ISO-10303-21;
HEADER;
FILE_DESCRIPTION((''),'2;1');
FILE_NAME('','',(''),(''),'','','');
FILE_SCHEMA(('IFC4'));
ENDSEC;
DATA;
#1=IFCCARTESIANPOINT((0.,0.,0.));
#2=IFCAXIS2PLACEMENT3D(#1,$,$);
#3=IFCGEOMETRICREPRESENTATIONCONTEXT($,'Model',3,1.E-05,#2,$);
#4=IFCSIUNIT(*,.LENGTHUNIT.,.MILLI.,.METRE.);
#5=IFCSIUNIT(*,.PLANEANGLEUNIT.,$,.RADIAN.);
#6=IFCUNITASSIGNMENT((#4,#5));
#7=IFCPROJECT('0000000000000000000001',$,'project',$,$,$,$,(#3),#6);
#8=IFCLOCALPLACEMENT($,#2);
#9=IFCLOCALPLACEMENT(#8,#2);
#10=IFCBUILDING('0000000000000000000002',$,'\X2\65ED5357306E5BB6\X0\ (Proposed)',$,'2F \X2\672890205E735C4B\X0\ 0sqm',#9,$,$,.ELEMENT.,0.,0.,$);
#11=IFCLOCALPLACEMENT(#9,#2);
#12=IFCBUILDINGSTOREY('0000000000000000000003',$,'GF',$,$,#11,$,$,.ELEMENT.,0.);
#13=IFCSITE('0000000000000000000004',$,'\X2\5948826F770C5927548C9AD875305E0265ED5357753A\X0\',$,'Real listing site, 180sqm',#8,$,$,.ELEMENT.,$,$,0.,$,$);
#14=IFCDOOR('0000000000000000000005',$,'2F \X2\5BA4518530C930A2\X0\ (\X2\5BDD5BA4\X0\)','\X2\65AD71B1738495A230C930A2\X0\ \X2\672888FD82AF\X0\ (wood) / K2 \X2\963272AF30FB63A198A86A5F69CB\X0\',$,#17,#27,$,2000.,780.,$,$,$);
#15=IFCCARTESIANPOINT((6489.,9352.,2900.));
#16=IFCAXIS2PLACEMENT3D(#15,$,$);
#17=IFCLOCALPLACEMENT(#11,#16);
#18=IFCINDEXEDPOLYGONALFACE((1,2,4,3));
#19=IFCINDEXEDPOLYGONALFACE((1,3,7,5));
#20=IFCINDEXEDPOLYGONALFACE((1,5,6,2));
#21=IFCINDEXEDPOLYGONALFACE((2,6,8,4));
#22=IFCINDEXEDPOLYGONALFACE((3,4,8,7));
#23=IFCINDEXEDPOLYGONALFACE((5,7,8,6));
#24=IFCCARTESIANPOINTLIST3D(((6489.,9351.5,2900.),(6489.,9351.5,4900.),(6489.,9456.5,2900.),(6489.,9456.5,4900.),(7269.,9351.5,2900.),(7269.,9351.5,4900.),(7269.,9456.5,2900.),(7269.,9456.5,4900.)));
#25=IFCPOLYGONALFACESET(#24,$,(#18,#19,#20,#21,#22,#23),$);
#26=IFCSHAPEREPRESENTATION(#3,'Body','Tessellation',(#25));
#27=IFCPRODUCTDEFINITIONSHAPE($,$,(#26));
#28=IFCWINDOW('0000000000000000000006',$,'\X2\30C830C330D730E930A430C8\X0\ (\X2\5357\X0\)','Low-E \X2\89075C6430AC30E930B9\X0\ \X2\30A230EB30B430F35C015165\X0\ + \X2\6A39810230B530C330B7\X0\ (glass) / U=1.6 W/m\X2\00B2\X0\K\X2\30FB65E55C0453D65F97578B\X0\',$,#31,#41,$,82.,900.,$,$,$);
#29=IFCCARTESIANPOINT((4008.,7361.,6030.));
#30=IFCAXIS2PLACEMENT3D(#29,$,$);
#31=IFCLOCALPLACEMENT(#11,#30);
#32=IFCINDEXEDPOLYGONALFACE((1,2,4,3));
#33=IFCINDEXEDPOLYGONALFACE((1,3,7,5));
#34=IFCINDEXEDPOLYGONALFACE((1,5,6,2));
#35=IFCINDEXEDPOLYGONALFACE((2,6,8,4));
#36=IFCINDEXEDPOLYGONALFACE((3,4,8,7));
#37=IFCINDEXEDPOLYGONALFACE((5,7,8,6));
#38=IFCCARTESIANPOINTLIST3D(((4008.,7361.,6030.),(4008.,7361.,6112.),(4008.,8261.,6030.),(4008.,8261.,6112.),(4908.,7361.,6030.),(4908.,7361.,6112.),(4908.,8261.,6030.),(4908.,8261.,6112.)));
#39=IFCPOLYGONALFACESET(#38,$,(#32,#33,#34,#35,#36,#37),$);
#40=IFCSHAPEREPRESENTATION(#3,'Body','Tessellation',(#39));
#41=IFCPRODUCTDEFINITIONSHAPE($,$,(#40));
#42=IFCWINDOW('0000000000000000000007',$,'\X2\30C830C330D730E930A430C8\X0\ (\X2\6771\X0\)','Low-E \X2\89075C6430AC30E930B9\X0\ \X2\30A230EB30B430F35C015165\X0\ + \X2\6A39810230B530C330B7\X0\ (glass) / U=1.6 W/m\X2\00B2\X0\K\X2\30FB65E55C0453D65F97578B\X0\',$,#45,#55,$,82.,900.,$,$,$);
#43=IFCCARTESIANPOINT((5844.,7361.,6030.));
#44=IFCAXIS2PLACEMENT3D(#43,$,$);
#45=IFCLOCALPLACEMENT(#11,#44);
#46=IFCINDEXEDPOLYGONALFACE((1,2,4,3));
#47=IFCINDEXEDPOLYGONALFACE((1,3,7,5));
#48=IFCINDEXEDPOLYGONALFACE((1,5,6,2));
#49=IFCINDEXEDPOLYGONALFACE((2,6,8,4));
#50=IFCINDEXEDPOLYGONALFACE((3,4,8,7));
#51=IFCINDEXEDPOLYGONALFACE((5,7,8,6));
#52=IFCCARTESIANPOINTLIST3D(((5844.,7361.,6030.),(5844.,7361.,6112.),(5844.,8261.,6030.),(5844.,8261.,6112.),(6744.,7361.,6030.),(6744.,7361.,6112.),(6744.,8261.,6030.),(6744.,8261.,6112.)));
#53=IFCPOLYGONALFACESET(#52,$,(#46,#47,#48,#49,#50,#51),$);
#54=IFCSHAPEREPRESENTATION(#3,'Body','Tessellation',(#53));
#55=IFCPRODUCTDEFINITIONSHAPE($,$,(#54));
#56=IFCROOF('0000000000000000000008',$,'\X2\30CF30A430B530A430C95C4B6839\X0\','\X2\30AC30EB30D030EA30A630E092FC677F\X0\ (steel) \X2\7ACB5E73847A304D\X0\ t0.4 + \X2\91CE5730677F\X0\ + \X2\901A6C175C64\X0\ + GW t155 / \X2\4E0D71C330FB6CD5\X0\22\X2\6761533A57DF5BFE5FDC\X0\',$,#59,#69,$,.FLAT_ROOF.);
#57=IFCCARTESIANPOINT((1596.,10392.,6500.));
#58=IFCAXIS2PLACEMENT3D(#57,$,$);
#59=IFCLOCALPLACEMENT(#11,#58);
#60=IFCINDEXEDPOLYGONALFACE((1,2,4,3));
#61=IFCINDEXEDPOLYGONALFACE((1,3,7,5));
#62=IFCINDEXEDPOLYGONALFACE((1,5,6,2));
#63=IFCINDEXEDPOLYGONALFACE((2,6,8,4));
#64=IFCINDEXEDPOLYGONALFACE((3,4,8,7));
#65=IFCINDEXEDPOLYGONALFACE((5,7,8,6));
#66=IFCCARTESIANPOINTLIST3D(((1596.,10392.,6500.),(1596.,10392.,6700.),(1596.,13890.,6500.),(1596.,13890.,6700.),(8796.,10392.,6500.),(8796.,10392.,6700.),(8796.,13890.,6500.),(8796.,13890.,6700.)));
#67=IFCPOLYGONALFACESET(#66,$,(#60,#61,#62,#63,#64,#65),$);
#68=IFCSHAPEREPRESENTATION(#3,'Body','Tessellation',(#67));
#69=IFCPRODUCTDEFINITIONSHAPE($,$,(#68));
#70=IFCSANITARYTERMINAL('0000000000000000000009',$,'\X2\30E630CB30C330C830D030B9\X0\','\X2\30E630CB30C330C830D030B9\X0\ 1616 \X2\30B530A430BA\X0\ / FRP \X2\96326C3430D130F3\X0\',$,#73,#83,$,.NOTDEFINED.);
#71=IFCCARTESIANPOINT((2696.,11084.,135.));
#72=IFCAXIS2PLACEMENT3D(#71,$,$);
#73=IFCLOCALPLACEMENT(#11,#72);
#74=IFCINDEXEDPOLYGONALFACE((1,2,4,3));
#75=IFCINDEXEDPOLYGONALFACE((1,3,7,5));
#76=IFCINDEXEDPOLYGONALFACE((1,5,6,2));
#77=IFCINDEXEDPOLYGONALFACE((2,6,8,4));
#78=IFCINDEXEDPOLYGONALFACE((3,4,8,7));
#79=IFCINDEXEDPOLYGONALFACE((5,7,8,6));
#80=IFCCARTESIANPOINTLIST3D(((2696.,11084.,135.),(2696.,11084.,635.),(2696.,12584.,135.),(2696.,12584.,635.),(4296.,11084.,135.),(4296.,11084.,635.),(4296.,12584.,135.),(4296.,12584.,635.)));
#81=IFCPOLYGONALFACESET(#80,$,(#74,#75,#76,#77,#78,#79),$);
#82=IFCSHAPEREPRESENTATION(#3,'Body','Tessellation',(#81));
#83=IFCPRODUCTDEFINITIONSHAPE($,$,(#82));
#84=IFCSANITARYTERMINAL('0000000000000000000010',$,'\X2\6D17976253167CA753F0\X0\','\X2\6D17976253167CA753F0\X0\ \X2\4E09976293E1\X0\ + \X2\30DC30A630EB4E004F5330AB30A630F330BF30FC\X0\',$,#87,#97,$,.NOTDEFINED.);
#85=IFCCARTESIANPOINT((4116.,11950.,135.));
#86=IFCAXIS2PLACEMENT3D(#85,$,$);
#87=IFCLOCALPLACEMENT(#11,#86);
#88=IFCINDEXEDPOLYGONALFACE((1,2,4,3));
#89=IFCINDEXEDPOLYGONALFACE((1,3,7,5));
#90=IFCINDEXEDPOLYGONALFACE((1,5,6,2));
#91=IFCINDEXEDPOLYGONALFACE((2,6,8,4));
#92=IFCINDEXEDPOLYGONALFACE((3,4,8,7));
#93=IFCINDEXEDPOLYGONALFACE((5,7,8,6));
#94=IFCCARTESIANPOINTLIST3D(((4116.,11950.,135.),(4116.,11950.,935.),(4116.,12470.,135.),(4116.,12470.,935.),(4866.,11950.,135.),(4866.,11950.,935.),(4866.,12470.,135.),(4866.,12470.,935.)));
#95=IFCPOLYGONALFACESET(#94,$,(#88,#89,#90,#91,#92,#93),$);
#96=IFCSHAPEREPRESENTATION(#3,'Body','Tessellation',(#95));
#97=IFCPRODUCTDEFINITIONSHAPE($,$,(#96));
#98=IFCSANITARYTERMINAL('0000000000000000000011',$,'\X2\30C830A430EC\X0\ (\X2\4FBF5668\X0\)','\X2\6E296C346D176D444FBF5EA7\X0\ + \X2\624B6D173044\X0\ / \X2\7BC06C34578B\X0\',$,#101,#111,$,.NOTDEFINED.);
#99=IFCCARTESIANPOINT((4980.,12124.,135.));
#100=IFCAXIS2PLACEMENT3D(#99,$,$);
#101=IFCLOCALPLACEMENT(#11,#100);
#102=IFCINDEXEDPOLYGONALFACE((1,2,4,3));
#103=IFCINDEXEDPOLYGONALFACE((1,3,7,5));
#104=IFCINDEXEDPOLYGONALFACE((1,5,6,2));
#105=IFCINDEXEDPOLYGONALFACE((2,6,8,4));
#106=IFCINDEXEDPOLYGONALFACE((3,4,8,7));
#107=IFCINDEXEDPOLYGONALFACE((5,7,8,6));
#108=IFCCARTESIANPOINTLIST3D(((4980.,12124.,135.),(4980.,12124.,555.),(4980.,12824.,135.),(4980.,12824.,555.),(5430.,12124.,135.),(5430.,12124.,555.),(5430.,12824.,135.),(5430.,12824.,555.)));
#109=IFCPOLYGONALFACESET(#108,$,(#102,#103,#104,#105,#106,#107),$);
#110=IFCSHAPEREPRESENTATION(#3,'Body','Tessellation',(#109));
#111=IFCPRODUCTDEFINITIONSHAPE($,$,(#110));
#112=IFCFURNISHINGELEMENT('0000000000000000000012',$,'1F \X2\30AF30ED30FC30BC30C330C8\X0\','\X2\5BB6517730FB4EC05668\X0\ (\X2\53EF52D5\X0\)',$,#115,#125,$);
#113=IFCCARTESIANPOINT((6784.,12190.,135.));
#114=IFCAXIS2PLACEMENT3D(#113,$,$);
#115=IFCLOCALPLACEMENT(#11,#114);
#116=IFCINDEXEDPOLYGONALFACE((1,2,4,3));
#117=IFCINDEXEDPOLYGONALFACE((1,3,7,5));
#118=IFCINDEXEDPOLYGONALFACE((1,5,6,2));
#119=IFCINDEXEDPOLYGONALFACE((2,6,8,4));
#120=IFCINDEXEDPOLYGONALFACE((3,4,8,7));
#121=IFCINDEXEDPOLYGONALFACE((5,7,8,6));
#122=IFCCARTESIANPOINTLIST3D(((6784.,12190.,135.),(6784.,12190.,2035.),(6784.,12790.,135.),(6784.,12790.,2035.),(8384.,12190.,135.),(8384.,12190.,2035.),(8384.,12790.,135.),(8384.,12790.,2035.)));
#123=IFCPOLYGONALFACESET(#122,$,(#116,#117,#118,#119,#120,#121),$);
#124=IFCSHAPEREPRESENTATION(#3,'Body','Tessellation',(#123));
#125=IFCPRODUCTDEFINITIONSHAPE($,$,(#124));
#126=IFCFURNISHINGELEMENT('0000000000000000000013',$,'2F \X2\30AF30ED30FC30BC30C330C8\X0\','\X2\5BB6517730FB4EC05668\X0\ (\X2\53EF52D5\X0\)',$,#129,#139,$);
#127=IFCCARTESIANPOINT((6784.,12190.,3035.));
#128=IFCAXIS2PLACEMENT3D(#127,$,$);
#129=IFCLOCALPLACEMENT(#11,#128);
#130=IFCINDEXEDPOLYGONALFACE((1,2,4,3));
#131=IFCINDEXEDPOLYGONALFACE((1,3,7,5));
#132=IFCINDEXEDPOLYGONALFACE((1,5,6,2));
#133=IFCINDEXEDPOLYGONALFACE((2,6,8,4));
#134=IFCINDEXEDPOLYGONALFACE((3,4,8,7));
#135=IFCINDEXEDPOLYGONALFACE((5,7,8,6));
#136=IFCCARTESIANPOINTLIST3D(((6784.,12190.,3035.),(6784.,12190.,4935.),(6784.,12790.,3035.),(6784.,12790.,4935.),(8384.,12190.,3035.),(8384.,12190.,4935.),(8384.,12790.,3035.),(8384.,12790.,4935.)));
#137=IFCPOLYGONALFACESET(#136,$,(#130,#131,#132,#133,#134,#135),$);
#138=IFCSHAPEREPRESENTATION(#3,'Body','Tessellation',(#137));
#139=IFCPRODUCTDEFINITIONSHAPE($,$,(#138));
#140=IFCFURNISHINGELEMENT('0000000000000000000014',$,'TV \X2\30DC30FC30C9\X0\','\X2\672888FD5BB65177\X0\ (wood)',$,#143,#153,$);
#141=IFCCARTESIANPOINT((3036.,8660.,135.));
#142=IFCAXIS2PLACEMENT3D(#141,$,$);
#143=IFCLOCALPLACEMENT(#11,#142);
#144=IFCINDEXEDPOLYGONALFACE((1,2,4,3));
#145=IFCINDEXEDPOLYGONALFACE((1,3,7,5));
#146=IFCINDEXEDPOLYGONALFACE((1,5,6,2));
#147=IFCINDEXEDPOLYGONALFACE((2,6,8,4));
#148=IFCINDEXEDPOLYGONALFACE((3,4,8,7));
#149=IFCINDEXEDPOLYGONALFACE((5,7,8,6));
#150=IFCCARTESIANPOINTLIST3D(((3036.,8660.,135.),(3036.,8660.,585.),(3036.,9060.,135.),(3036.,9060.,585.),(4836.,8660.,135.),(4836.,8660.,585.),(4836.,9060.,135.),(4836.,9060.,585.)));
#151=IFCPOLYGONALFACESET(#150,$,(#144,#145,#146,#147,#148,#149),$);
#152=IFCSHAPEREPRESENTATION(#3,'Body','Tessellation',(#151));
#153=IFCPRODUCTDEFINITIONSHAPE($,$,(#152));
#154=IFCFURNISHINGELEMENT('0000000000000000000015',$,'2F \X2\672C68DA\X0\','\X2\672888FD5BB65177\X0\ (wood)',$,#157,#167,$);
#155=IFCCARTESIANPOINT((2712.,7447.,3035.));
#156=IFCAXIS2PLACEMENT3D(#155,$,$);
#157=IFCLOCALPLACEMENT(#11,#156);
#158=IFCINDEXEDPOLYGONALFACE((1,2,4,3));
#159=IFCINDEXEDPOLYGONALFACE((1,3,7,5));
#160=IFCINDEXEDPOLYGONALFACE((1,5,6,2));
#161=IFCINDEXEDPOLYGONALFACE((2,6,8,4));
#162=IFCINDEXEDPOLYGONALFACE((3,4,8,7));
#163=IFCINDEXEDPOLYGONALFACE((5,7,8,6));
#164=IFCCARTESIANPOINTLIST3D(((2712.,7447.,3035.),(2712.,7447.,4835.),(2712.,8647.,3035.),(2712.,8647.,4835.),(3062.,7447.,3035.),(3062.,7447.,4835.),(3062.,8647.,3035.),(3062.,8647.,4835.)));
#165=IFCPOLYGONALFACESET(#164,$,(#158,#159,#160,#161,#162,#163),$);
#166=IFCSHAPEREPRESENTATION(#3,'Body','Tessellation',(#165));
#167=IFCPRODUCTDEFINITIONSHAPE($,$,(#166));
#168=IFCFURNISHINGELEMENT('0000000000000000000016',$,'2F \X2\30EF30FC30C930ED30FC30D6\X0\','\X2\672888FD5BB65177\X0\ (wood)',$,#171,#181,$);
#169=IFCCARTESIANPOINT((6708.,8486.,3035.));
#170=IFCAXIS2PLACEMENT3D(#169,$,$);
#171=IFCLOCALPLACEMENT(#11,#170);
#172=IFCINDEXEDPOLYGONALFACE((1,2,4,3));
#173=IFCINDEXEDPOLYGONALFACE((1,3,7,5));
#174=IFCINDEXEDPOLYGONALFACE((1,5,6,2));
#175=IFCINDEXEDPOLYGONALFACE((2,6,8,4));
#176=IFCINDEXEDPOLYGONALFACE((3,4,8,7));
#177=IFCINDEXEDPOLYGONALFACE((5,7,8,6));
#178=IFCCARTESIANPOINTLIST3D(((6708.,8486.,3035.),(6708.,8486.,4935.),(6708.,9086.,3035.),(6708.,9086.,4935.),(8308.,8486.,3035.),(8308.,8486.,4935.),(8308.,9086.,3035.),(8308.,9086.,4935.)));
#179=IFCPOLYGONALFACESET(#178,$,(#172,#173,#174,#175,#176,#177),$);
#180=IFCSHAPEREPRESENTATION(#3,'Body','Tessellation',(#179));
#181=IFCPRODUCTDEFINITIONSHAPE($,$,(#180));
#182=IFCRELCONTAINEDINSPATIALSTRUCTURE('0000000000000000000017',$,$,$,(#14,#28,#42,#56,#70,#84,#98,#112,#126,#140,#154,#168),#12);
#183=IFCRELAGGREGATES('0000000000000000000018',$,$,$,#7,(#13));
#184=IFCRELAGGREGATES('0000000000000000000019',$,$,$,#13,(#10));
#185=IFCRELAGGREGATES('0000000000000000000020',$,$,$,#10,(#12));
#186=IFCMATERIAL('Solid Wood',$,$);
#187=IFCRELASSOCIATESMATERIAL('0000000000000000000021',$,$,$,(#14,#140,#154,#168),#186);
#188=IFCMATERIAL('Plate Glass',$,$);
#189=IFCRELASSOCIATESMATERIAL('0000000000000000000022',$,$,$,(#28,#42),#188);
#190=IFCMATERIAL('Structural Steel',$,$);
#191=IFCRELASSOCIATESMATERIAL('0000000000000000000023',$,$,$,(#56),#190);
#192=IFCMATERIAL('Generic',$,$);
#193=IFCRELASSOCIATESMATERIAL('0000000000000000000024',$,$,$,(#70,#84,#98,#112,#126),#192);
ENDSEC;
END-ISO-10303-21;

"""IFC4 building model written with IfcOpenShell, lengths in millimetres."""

from ifc_helpers import new_model, si_unit, frame, frame_2d, origin, place, context, project, spatial, rectangle, extrude, material, element, save


model = new_model("IFC4")

# Units and contexts
model_context = context("Model", 3, precision=1e-05, world=origin())
ifc_project = project(units=[si_unit("LENGTHUNIT", "METRE", prefix="MILLI"), si_unit("PLANEANGLEUNIT", "RADIAN")], contexts=[model_context])

# Site, building, storey
site_placement = place(None, origin())
site = spatial("IfcSite", under=ifc_project, at=site_placement, Name="奈良県大和高田市旭南町", ObjectType="Real listing site, 180sqm", CompositionType="ELEMENT", RefElevation=0.0)
building_placement = place(site_placement, origin())
building = spatial("IfcBuilding", under=site, at=building_placement, Name="旭南の家 (Proposed)", ObjectType="2F 木造平屋 0sqm", CompositionType="ELEMENT", ElevationOfRefHeight=0.0, ElevationOfTerrain=0.0)
storey_placement = place(building_placement, origin())
storey = spatial("IfcBuildingStorey", under=building, at=storey_placement, Name="GF", CompositionType="ELEMENT", Elevation=0.0)

# Shared definitions
ifc_material_1 = material(Name="Solid Wood")
ifc_material_2 = material(Name="Plate Glass")

# Door
door_1_placement = place(storey_placement, frame((6489.0, 9352.0, 2900.0)))
element("IfcDoor", 1, at=door_1_placement, inside=storey, material=ifc_material_1, Name="2F 室内ドア (寝室)", Description="断熱玄関ドア 木製芯 (wood) / K2 防犯・採風機構", OverallHeight=2000.0, OverallWidth=780.0, context=model_context, shape_type="SweptSolid", body=[
    extrude(rectangle(XDim=780.0, YDim=105.0, at=frame_2d((390.0, 52.0))), frame((6489.0, 9352.0, 2900.0)), (0.0, 0.0, 1.0), 2000.0),
])

# Windows
window_1_placement = place(storey_placement, frame((4008.0, 7361.0, 6030.0)))
element("IfcWindow", 2, at=window_1_placement, inside=storey, material=ifc_material_2, Name="トップライト (南)", Description="Low-E 複層ガラス アルゴン封入 + 樹脂サッシ (glass) / U=1.6 W/m²K・日射取得型", OverallHeight=82.0, OverallWidth=900.0, context=model_context, shape_type="SweptSolid", body=[
    extrude(rectangle(XDim=900.0, YDim=900.0, at=frame_2d((450.0, 450.0))), frame((4008.0, 7361.0, 6030.0)), (0.0, 0.0, 1.0), 82.0),
])
window_2_placement = place(storey_placement, frame((5844.0, 7361.0, 6030.0)))
element("IfcWindow", 3, at=window_2_placement, inside=storey, material=ifc_material_2, Name="トップライト (東)", Description="Low-E 複層ガラス アルゴン封入 + 樹脂サッシ (glass) / U=1.6 W/m²K・日射取得型", OverallHeight=82.0, OverallWidth=900.0, context=model_context, shape_type="SweptSolid", body=[
    extrude(rectangle(XDim=900.0, YDim=900.0, at=frame_2d((450.0, 450.0))), frame((5844.0, 7361.0, 6030.0)), (0.0, 0.0, 1.0), 82.0),
])

# Roof
ifc_material_3 = material(Name="Structural Steel")
roof_placement = place(storey_placement, frame((1596.0, 10392.0, 6500.0)))
element("IfcRoof", 4, at=roof_placement, inside=storey, material=ifc_material_3, Name="ハイサイド屋根", Description="ガルバリウム鋼板 (steel) 立平葺き t0.4 + 野地板 + 通気層 + GW t155 / 不燃・法22条区域対応", PredefinedType="FLAT_ROOF", context=model_context, shape_type="SweptSolid", body=[
    extrude(rectangle(XDim=7200.0, YDim=3498.0, at=frame_2d((3600.0, 1749.0))), frame((1596.0, 10392.0, 6500.0)), (0.0, 0.0, 1.0), 200.0),
])

# Sanitary terminals
ifc_material_4 = material(Name="Generic")
sanitary_terminal_1_placement = place(storey_placement, frame((2696.0, 11084.0, 135.0)))
element("IfcSanitaryTerminal", 5, at=sanitary_terminal_1_placement, inside=storey, material=ifc_material_4, Name="ユニットバス", Description="ユニットバス 1616 サイズ / FRP 防水パン", PredefinedType="NOTDEFINED", context=model_context, shape_type="SweptSolid", body=[
    extrude(rectangle(XDim=1600.0, YDim=1500.0, at=frame_2d((800.0, 750.0))), frame((2696.0, 11084.0, 135.0)), (0.0, 0.0, 1.0), 500.0),
])
sanitary_terminal_2_placement = place(storey_placement, frame((4116.0, 11950.0, 135.0)))
element("IfcSanitaryTerminal", 6, at=sanitary_terminal_2_placement, inside=storey, material=ifc_material_4, Name="洗面化粧台", Description="洗面化粧台 三面鏡 + ボウル一体カウンター", PredefinedType="NOTDEFINED", context=model_context, shape_type="SweptSolid", body=[
    extrude(rectangle(XDim=750.0, YDim=520.0, at=frame_2d((375.0, 260.0))), frame((4116.0, 11950.0, 135.0)), (0.0, 0.0, 1.0), 800.0),
])
sanitary_terminal_3_placement = place(storey_placement, frame((4980.0, 12124.0, 135.0)))
element("IfcSanitaryTerminal", 7, at=sanitary_terminal_3_placement, inside=storey, material=ifc_material_4, Name="トイレ (便器)", Description="温水洗浄便座 + 手洗い / 節水型", PredefinedType="NOTDEFINED", context=model_context, shape_type="SweptSolid", body=[
    extrude(rectangle(XDim=450.0, YDim=700.0, at=frame_2d((225.0, 350.0))), frame((4980.0, 12124.0, 135.0)), (0.0, 0.0, 1.0), 420.0),
])

# Furnishing elements
furnishing_1_placement = place(storey_placement, frame((6784.0, 12190.0, 135.0)))
element("IfcFurnishingElement", 8, at=furnishing_1_placement, inside=storey, material=ifc_material_4, Name="1F クローゼット", Description="家具・什器 (可動)", context=model_context, shape_type="SweptSolid", body=[
    extrude(rectangle(XDim=1600.0, YDim=600.0, at=frame_2d((800.0, 300.0))), frame((6784.0, 12190.0, 135.0)), (0.0, 0.0, 1.0), 1900.0),
])
furnishing_2_placement = place(storey_placement, frame((6784.0, 12190.0, 3035.0)))
element("IfcFurnishingElement", 9, at=furnishing_2_placement, inside=storey, material=ifc_material_4, Name="2F クローゼット", Description="家具・什器 (可動)", context=model_context, shape_type="SweptSolid", body=[
    extrude(rectangle(XDim=1600.0, YDim=600.0, at=frame_2d((800.0, 300.0))), frame((6784.0, 12190.0, 3035.0)), (0.0, 0.0, 1.0), 1900.0),
])
furnishing_3_placement = place(storey_placement, frame((3036.0, 8660.0, 135.0)))
element("IfcFurnishingElement", 10, at=furnishing_3_placement, inside=storey, material=ifc_material_1, Name="TV ボード", Description="木製家具 (wood)", context=model_context, shape_type="SweptSolid", body=[
    extrude(rectangle(XDim=1800.0, YDim=400.0, at=frame_2d((900.0, 200.0))), frame((3036.0, 8660.0, 135.0)), (0.0, 0.0, 1.0), 450.0),
])
furnishing_4_placement = place(storey_placement, frame((2712.0, 7447.0, 3035.0)))
element("IfcFurnishingElement", 11, at=furnishing_4_placement, inside=storey, material=ifc_material_1, Name="2F 本棚", Description="木製家具 (wood)", context=model_context, shape_type="SweptSolid", body=[
    extrude(rectangle(XDim=350.0, YDim=1200.0, at=frame_2d((175.0, 600.0))), frame((2712.0, 7447.0, 3035.0)), (0.0, 0.0, 1.0), 1800.0),
])
furnishing_5_placement = place(storey_placement, frame((6708.0, 8486.0, 3035.0)))
element("IfcFurnishingElement", 12, at=furnishing_5_placement, inside=storey, material=ifc_material_1, Name="2F ワードローブ", Description="木製家具 (wood)", context=model_context, shape_type="SweptSolid", body=[
    extrude(rectangle(XDim=1600.0, YDim=600.0, at=frame_2d((800.0, 300.0))), frame((6708.0, 8486.0, 3035.0)), (0.0, 0.0, 1.0), 1900.0),
])

save(model, "model.ifc")
